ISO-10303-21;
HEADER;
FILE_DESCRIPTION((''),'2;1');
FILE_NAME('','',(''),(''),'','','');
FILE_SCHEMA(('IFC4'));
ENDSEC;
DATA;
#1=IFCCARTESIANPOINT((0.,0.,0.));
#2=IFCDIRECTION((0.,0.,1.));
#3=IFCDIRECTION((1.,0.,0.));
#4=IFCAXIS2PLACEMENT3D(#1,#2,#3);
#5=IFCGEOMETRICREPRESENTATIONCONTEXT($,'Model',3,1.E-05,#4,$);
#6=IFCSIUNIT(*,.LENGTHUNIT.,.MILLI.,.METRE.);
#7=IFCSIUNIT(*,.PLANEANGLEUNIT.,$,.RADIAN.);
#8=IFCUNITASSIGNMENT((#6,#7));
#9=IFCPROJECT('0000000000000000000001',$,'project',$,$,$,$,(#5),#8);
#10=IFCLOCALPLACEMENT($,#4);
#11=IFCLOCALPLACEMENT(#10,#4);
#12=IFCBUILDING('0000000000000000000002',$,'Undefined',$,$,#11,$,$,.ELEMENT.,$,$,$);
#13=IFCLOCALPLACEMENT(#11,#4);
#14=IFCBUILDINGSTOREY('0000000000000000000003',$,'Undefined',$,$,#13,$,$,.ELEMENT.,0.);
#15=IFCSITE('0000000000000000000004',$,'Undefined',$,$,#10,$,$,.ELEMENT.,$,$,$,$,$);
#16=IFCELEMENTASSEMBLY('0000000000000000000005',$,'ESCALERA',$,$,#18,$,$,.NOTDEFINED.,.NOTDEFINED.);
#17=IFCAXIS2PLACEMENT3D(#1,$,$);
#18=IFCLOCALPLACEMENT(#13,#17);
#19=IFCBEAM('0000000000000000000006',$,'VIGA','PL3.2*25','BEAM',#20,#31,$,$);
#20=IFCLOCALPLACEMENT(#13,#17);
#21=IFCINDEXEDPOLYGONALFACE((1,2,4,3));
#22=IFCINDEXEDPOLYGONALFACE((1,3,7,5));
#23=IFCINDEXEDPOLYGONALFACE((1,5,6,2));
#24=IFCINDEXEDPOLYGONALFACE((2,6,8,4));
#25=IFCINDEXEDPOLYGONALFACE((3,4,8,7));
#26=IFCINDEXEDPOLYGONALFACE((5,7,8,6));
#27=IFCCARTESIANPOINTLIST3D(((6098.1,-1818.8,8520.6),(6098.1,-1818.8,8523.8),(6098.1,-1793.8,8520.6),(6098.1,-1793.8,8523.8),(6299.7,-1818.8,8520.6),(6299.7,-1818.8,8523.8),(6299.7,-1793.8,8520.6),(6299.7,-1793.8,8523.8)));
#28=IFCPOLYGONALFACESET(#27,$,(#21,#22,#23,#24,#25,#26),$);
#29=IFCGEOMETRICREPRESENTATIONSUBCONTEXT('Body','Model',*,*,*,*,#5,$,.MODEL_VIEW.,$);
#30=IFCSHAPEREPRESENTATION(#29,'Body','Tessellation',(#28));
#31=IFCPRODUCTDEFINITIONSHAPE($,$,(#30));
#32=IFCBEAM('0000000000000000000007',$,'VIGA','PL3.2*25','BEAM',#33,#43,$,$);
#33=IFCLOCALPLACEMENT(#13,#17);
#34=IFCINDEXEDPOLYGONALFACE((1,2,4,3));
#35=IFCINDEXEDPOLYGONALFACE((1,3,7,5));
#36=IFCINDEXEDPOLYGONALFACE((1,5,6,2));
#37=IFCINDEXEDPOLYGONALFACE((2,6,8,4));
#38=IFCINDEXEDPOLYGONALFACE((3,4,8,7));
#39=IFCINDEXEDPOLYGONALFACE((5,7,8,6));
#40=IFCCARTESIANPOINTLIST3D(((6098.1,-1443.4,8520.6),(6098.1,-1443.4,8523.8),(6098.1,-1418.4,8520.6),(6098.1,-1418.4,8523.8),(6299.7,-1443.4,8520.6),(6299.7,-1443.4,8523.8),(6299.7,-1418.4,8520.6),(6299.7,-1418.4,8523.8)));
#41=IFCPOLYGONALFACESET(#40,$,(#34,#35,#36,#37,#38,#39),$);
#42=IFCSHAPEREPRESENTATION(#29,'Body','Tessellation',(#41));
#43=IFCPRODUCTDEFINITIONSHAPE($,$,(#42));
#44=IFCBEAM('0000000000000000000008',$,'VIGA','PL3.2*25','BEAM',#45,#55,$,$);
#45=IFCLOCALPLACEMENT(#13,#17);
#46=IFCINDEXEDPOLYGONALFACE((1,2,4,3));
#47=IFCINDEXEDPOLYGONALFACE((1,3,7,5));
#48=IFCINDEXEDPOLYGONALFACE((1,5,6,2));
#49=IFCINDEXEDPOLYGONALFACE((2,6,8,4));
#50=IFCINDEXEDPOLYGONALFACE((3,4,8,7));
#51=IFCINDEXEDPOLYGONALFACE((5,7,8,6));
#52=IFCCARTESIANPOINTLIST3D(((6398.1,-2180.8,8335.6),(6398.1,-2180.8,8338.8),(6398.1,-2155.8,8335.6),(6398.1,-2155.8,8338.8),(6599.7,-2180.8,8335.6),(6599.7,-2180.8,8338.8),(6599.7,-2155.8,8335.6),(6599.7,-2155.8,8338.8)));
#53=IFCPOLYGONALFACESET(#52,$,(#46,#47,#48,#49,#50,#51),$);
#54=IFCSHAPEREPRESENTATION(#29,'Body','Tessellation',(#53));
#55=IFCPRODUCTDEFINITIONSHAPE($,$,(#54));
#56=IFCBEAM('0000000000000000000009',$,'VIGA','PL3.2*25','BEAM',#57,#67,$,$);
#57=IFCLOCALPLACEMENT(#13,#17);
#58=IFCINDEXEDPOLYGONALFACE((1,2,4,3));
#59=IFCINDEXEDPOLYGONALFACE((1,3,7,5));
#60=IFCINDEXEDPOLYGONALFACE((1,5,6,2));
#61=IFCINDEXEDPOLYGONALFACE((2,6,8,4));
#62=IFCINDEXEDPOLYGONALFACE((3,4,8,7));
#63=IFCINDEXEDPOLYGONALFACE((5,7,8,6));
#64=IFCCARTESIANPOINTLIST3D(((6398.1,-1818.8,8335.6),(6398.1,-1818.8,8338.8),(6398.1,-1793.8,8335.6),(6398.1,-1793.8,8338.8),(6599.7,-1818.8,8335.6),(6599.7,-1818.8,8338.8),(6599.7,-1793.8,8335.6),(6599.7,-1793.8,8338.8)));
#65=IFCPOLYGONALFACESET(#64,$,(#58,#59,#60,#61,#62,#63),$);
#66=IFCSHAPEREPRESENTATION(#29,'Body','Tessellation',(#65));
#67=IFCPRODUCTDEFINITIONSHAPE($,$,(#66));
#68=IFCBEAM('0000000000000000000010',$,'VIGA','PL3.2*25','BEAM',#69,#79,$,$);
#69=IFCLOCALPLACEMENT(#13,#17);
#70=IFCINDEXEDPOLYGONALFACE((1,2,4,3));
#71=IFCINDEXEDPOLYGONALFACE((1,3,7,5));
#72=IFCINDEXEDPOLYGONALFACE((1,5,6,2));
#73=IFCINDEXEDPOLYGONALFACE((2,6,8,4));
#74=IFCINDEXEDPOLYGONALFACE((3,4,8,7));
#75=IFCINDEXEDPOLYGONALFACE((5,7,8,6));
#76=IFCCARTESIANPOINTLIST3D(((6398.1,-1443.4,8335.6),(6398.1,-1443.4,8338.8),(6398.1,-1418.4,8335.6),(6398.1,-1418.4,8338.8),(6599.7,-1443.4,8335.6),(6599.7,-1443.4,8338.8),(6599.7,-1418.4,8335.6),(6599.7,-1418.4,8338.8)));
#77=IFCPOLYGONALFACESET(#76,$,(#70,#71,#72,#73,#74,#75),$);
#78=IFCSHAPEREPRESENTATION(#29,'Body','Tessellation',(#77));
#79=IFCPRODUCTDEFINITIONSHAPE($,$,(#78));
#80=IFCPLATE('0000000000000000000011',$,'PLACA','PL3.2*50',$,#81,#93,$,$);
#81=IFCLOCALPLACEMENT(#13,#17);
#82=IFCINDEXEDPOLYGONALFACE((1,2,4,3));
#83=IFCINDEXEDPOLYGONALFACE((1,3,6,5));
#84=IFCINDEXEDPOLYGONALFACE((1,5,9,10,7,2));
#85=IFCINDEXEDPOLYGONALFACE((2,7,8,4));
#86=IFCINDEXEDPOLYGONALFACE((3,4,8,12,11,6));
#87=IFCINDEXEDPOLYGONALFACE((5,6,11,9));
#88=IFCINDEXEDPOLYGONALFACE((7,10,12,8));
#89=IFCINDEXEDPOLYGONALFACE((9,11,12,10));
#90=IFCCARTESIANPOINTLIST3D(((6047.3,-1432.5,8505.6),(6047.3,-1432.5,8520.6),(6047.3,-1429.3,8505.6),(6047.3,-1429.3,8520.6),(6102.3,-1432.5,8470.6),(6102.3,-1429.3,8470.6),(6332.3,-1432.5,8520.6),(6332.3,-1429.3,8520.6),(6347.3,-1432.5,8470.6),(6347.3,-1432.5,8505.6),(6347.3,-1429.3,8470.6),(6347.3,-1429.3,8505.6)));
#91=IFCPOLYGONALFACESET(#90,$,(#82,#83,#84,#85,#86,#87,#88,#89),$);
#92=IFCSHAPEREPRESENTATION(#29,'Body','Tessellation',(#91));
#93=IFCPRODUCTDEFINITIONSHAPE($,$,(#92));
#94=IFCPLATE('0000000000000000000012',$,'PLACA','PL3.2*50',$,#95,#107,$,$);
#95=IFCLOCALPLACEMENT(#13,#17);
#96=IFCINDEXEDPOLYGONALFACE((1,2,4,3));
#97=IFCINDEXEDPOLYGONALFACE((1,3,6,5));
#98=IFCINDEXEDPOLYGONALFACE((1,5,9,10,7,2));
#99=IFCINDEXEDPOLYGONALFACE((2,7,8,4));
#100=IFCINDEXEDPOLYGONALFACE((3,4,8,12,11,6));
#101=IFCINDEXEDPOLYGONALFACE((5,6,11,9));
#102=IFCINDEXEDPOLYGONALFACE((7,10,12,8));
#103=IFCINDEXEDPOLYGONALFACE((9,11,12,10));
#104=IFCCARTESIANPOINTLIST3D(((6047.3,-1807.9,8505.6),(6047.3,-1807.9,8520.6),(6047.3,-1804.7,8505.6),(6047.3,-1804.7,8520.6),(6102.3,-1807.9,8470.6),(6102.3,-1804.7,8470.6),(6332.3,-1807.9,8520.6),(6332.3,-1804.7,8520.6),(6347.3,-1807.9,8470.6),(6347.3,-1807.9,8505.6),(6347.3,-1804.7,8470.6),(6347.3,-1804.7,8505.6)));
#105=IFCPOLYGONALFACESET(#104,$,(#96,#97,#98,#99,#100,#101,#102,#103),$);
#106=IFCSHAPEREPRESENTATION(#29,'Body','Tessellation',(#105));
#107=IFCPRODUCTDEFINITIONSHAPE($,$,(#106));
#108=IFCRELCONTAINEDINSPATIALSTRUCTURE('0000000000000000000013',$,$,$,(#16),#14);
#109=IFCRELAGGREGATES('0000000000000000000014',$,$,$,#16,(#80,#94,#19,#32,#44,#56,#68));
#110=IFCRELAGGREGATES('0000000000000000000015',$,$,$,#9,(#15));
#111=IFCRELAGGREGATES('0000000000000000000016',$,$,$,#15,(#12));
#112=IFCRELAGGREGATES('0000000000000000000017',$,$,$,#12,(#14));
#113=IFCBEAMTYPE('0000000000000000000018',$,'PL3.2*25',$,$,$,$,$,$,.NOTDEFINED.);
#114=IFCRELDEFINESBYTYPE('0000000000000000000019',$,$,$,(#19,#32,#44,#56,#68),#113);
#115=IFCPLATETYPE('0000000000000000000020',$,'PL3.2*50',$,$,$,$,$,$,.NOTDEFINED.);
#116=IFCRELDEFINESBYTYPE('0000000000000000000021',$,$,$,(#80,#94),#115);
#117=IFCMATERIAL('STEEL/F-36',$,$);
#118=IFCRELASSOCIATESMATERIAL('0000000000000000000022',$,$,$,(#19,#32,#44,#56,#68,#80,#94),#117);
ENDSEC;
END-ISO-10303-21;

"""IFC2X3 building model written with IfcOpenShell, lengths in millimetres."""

from ifc_helpers import new_model, si_unit, frame, origin_with_axes, origin_2d_with_axis, place, context, subcontext, project, spatial, polyline, rectangle, outline, extrude, material, type_object, element, aggregate, save


model = new_model("IFC2X3")

# Units and contexts
model_context = context("Model", 3, precision=1e-05, world=origin_with_axes())
body_context = subcontext(model_context, "Body", "Model", "MODEL_VIEW")
ifc_project = project(units=[si_unit("LENGTHUNIT", "METRE", prefix="MILLI"), si_unit("PLANEANGLEUNIT", "RADIAN")], contexts=[model_context])

# Site, building, storey
site_placement = place(None, origin_with_axes())
site = spatial("IfcSite", under=ifc_project, at=site_placement, Name="Undefined", CompositionType="ELEMENT")
building_placement = place(site_placement, origin_with_axes())
building = spatial("IfcBuilding", under=site, at=building_placement, Name="Undefined", CompositionType="ELEMENT")
storey_placement = place(building_placement, origin_with_axes())
storey = spatial("IfcBuildingStorey", under=building, at=storey_placement, Name="Undefined", CompositionType="ELEMENT", Elevation=0.0)

# Element assembly
assembly_1_placement = place(storey_placement, origin_with_axes())
assembly_1 = element("IfcElementAssembly", 1, at=assembly_1_placement, inside=storey, Name="ESCALERA", AssemblyPlace="NOTDEFINED", PredefinedType="NOTDEFINED")
ifc_material_1 = material(Name="STEEL/F-36")

# Beams
beam_type_1 = type_object("IfcBeamType", Name="PL3.2*25", PredefinedType="NOTDEFINED")
beam_1_placement = place(assembly_1_placement, frame((6299.7, -1806.3, 8522.2), z_axis=(0.0, 1.0, 0.0), x_axis=(-1.0, 0.0, 0.000012)))
beam_1 = element("IfcBeam", 2, at=beam_1_placement, type_object=beam_type_1, material=ifc_material_1, Name="VIGA", Description="PL3.2*25", ObjectType="BEAM", context=body_context, shape_type="SweptSolid", body=[
    extrude(rectangle(XDim=3.2, YDim=25.0, at=origin_2d_with_axis()), frame((201.6, 0.0, 0.0), z_axis=(-1.0, 0.0, 0.0), x_axis=(0.0, -1.0, 0.0)), (0.0, 0.0, 1.0), 201.6),
])
beam_2_placement = place(assembly_1_placement, frame((6299.7, -1430.9, 8522.2), z_axis=(0.0, 1.0, 0.0), x_axis=(-1.0, 0.0, 0.000012)))
beam_2 = element("IfcBeam", 3, at=beam_2_placement, type_object=beam_type_1, material=ifc_material_1, Name="VIGA", Description="PL3.2*25", ObjectType="BEAM", context=body_context, shape_type="SweptSolid", body=[
    extrude(rectangle(XDim=3.2, YDim=25.0, at=origin_2d_with_axis()), frame((201.6, 0.0, 0.0), z_axis=(-1.0, 0.0, 0.0), x_axis=(0.0, -1.0, 0.0)), (0.0, 0.0, 1.0), 201.6),
])
beam_3_placement = place(assembly_1_placement, frame((6599.7, -2168.3, 8337.2), z_axis=(0.0, 1.0, 0.0), x_axis=(-1.0, 0.0, 0.000012)))
beam_3 = element("IfcBeam", 4, at=beam_3_placement, type_object=beam_type_1, material=ifc_material_1, Name="VIGA", Description="PL3.2*25", ObjectType="BEAM", context=body_context, shape_type="SweptSolid", body=[
    extrude(rectangle(XDim=3.2, YDim=25.0, at=origin_2d_with_axis()), frame((201.6, 0.0, 0.0), z_axis=(-1.0, 0.0, 0.0), x_axis=(0.0, -1.0, 0.0)), (0.0, 0.0, 1.0), 201.6),
])
beam_4_placement = place(assembly_1_placement, frame((6599.7, -1806.3, 8337.2), z_axis=(0.0, 1.0, 0.0), x_axis=(-1.0, 0.0, 0.000012)))
beam_4 = element("IfcBeam", 5, at=beam_4_placement, type_object=beam_type_1, material=ifc_material_1, Name="VIGA", Description="PL3.2*25", ObjectType="BEAM", context=body_context, shape_type="SweptSolid", body=[
    extrude(rectangle(XDim=3.2, YDim=25.0, at=origin_2d_with_axis()), frame((201.6, 0.0, 0.0), z_axis=(-1.0, 0.0, 0.0), x_axis=(0.0, -1.0, 0.0)), (0.0, 0.0, 1.0), 201.6),
])
beam_5_placement = place(assembly_1_placement, frame((6599.7, -1430.9, 8337.2), z_axis=(0.0, 1.0, 0.0), x_axis=(-1.0, 0.0, 0.000012)))
beam_5 = element("IfcBeam", 6, at=beam_5_placement, type_object=beam_type_1, material=ifc_material_1, Name="VIGA", Description="PL3.2*25", ObjectType="BEAM", context=body_context, shape_type="SweptSolid", body=[
    extrude(rectangle(XDim=3.2, YDim=25.0, at=origin_2d_with_axis()), frame((201.6, 0.0, 0.0), z_axis=(-1.0, 0.0, 0.0), x_axis=(0.0, -1.0, 0.0)), (0.0, 0.0, 1.0), 201.6),
])

# Plates
plate_type = type_object("IfcPlateType", Name="PL3.2*50", PredefinedType="NOTDEFINED")
plate_1_placement = place(assembly_1_placement, frame((6047.3, -1430.9, 8520.6), z_axis=(0.0, -1.0, 0.0), x_axis=(0.0, 0.0, -1.0)))
plate_1 = element("IfcPlate", 7, at=plate_1_placement, type_object=plate_type, material=ifc_material_1, Name="PLACA", Description="PL3.2*50", context=body_context, shape_type="SweptSolid", body=[
    extrude(outline(polyline([(0.0, 0.0), (15.0, 0.0), (50.0, 55.0), (50.0, 300.0), (50.0, 300.0), (15.0, 300.0), (0.0, 285.0), (0.0, 0.0)])), frame((0.0, 0.0, -1.6), z_axis=(0.0, 0.0, 1.0), x_axis=(1.0, 0.0, 0.0)), (0.0, 0.0, 1.0), 3.2),
])
plate_2_placement = place(assembly_1_placement, frame((6047.3, -1806.3, 8520.6), z_axis=(0.0, -1.0, 0.0), x_axis=(0.0, 0.0, -1.0)))
plate_2 = element("IfcPlate", 8, at=plate_2_placement, type_object=plate_type, material=ifc_material_1, Name="PLACA", Description="PL3.2*50", context=body_context, shape_type="SweptSolid", body=[
    extrude(outline(polyline([(0.0, 0.0), (15.0, 0.0), (50.0, 55.0), (50.0, 300.0), (50.0, 300.0), (15.0, 300.0), (0.0, 285.0), (0.0, 0.0)])), frame((0.0, 0.0, -1.6), z_axis=(0.0, 0.0, 1.0), x_axis=(1.0, 0.0, 0.0)), (0.0, 0.0, 1.0), 3.2),
])
aggregate(assembly_1, [plate_1, plate_2, beam_1, beam_2, beam_3, beam_4, beam_5])

save(model, "model.ifc")
